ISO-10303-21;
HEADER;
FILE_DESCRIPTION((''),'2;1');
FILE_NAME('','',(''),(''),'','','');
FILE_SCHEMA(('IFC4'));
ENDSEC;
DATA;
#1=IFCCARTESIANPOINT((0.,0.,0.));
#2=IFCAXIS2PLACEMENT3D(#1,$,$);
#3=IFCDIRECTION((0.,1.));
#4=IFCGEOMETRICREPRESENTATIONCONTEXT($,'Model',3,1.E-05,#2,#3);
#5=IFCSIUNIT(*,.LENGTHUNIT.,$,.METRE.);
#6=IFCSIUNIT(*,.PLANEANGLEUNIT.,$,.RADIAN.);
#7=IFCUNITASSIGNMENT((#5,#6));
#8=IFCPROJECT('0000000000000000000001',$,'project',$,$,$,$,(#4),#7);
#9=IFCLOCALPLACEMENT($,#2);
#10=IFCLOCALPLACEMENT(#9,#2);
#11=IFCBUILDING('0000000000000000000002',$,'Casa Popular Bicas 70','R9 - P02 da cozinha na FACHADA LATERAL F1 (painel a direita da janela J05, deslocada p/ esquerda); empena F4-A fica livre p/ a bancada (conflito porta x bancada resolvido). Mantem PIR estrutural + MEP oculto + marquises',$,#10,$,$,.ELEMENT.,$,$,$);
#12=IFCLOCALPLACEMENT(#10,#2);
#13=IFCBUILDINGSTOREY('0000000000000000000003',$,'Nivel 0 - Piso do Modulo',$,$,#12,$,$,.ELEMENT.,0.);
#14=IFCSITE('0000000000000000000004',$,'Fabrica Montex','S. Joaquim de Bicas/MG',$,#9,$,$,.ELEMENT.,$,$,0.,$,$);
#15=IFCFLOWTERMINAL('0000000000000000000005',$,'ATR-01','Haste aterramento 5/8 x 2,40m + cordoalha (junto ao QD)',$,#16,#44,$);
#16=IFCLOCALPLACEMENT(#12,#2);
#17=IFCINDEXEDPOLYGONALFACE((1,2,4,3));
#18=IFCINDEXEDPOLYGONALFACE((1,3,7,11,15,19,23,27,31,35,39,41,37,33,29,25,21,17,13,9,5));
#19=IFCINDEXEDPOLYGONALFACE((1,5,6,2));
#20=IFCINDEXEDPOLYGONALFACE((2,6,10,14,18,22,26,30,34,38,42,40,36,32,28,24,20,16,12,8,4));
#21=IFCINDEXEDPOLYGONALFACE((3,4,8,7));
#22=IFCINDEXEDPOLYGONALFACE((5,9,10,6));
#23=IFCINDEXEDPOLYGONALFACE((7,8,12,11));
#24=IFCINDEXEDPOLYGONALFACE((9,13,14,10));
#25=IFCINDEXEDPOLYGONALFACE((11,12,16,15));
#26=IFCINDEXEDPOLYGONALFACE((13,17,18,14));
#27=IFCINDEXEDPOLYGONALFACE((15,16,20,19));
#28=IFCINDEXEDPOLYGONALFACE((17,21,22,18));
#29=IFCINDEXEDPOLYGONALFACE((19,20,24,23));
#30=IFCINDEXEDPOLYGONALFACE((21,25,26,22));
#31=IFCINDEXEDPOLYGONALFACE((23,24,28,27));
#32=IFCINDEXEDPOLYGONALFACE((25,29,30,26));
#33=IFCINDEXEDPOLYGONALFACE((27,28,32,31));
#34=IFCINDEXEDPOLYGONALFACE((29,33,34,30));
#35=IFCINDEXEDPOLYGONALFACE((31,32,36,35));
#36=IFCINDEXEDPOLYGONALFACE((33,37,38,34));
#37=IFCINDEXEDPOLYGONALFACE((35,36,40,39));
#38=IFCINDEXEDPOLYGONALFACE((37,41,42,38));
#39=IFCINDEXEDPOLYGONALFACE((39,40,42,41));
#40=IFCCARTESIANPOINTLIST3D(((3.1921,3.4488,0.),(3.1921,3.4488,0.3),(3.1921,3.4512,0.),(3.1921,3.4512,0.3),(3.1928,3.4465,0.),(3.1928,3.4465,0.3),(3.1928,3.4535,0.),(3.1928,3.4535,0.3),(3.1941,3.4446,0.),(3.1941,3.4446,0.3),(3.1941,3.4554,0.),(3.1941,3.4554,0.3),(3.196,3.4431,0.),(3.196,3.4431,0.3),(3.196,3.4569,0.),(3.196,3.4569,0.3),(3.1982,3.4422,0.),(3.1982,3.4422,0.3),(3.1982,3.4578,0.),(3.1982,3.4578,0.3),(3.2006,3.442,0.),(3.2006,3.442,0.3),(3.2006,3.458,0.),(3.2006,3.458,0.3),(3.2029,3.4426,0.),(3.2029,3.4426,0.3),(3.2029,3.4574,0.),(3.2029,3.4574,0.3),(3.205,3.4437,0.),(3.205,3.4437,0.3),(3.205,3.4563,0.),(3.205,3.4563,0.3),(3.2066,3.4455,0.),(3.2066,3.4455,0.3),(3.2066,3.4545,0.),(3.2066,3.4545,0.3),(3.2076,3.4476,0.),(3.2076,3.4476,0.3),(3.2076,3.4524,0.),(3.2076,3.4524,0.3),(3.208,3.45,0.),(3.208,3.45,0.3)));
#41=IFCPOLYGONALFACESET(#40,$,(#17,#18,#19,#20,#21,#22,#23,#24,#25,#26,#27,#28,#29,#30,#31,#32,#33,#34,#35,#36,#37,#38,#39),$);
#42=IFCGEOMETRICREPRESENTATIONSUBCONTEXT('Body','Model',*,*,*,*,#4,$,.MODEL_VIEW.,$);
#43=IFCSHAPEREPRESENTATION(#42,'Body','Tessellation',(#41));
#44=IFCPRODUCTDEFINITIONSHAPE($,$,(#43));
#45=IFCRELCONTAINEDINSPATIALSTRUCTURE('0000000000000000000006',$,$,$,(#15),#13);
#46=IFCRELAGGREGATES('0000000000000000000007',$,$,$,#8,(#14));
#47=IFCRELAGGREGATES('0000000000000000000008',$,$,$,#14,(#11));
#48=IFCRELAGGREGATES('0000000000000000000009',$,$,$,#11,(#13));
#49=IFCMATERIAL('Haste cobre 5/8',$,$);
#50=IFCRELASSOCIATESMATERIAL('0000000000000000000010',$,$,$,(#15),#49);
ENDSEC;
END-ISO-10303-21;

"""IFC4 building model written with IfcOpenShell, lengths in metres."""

from ifc_helpers import new_model, si_unit, direction, frame, origin, origin_2d, place, context, subcontext, project, spatial, circle, extrude, material, element, save


model = new_model("IFC4")

# Units and contexts
model_context = context("Model", 3, precision=1e-05, world=origin(), true_north=direction((0.0, 1.0)))
body_context = subcontext(model_context, "Body", "Model", "MODEL_VIEW")
ifc_project = project(units=[si_unit("LENGTHUNIT", "METRE"), si_unit("PLANEANGLEUNIT", "RADIAN")], contexts=[model_context])

# Site, building, storey
site_placement = place(None, origin())
site = spatial("IfcSite", under=ifc_project, at=site_placement, Name="Fabrica Montex", Description="S. Joaquim de Bicas/MG", CompositionType="ELEMENT", RefElevation=0.0)
building_placement = place(site_placement, origin())
building = spatial("IfcBuilding", under=site, at=building_placement, Name="Casa Popular Bicas 70", Description="R9 - P02 da cozinha na FACHADA LATERAL F1 (painel a direita da janela J05, deslocada p/ esquerda); empena F4-A fica livre p/ a bancada (conflito porta x bancada resolvido). Mantem PIR estrutural + MEP oculto + marquises", CompositionType="ELEMENT")
storey_placement = place(building_placement, origin())
storey = spatial("IfcBuildingStorey", under=building, at=storey_placement, Name="Nivel 0 - Piso do Modulo", CompositionType="ELEMENT", Elevation=0.0)

# Flow terminal
ifc_material_1 = material(Name="Haste cobre 5/8")
flow_terminal_placement = place(storey_placement, frame((3.2, 3.45, 0.0)))
element("IfcFlowTerminal", 1, at=flow_terminal_placement, inside=storey, material=ifc_material_1, Name="ATR-01", Description="Haste aterramento 5/8 x 2,40m + cordoalha (junto ao QD)", context=body_context, shape_type="SweptSolid", body=[
    extrude(circle(Radius=0.008, at=origin_2d()), origin(), (0.0, 0.0, 1.0), 0.3),
])

save(model, "model.ifc")
